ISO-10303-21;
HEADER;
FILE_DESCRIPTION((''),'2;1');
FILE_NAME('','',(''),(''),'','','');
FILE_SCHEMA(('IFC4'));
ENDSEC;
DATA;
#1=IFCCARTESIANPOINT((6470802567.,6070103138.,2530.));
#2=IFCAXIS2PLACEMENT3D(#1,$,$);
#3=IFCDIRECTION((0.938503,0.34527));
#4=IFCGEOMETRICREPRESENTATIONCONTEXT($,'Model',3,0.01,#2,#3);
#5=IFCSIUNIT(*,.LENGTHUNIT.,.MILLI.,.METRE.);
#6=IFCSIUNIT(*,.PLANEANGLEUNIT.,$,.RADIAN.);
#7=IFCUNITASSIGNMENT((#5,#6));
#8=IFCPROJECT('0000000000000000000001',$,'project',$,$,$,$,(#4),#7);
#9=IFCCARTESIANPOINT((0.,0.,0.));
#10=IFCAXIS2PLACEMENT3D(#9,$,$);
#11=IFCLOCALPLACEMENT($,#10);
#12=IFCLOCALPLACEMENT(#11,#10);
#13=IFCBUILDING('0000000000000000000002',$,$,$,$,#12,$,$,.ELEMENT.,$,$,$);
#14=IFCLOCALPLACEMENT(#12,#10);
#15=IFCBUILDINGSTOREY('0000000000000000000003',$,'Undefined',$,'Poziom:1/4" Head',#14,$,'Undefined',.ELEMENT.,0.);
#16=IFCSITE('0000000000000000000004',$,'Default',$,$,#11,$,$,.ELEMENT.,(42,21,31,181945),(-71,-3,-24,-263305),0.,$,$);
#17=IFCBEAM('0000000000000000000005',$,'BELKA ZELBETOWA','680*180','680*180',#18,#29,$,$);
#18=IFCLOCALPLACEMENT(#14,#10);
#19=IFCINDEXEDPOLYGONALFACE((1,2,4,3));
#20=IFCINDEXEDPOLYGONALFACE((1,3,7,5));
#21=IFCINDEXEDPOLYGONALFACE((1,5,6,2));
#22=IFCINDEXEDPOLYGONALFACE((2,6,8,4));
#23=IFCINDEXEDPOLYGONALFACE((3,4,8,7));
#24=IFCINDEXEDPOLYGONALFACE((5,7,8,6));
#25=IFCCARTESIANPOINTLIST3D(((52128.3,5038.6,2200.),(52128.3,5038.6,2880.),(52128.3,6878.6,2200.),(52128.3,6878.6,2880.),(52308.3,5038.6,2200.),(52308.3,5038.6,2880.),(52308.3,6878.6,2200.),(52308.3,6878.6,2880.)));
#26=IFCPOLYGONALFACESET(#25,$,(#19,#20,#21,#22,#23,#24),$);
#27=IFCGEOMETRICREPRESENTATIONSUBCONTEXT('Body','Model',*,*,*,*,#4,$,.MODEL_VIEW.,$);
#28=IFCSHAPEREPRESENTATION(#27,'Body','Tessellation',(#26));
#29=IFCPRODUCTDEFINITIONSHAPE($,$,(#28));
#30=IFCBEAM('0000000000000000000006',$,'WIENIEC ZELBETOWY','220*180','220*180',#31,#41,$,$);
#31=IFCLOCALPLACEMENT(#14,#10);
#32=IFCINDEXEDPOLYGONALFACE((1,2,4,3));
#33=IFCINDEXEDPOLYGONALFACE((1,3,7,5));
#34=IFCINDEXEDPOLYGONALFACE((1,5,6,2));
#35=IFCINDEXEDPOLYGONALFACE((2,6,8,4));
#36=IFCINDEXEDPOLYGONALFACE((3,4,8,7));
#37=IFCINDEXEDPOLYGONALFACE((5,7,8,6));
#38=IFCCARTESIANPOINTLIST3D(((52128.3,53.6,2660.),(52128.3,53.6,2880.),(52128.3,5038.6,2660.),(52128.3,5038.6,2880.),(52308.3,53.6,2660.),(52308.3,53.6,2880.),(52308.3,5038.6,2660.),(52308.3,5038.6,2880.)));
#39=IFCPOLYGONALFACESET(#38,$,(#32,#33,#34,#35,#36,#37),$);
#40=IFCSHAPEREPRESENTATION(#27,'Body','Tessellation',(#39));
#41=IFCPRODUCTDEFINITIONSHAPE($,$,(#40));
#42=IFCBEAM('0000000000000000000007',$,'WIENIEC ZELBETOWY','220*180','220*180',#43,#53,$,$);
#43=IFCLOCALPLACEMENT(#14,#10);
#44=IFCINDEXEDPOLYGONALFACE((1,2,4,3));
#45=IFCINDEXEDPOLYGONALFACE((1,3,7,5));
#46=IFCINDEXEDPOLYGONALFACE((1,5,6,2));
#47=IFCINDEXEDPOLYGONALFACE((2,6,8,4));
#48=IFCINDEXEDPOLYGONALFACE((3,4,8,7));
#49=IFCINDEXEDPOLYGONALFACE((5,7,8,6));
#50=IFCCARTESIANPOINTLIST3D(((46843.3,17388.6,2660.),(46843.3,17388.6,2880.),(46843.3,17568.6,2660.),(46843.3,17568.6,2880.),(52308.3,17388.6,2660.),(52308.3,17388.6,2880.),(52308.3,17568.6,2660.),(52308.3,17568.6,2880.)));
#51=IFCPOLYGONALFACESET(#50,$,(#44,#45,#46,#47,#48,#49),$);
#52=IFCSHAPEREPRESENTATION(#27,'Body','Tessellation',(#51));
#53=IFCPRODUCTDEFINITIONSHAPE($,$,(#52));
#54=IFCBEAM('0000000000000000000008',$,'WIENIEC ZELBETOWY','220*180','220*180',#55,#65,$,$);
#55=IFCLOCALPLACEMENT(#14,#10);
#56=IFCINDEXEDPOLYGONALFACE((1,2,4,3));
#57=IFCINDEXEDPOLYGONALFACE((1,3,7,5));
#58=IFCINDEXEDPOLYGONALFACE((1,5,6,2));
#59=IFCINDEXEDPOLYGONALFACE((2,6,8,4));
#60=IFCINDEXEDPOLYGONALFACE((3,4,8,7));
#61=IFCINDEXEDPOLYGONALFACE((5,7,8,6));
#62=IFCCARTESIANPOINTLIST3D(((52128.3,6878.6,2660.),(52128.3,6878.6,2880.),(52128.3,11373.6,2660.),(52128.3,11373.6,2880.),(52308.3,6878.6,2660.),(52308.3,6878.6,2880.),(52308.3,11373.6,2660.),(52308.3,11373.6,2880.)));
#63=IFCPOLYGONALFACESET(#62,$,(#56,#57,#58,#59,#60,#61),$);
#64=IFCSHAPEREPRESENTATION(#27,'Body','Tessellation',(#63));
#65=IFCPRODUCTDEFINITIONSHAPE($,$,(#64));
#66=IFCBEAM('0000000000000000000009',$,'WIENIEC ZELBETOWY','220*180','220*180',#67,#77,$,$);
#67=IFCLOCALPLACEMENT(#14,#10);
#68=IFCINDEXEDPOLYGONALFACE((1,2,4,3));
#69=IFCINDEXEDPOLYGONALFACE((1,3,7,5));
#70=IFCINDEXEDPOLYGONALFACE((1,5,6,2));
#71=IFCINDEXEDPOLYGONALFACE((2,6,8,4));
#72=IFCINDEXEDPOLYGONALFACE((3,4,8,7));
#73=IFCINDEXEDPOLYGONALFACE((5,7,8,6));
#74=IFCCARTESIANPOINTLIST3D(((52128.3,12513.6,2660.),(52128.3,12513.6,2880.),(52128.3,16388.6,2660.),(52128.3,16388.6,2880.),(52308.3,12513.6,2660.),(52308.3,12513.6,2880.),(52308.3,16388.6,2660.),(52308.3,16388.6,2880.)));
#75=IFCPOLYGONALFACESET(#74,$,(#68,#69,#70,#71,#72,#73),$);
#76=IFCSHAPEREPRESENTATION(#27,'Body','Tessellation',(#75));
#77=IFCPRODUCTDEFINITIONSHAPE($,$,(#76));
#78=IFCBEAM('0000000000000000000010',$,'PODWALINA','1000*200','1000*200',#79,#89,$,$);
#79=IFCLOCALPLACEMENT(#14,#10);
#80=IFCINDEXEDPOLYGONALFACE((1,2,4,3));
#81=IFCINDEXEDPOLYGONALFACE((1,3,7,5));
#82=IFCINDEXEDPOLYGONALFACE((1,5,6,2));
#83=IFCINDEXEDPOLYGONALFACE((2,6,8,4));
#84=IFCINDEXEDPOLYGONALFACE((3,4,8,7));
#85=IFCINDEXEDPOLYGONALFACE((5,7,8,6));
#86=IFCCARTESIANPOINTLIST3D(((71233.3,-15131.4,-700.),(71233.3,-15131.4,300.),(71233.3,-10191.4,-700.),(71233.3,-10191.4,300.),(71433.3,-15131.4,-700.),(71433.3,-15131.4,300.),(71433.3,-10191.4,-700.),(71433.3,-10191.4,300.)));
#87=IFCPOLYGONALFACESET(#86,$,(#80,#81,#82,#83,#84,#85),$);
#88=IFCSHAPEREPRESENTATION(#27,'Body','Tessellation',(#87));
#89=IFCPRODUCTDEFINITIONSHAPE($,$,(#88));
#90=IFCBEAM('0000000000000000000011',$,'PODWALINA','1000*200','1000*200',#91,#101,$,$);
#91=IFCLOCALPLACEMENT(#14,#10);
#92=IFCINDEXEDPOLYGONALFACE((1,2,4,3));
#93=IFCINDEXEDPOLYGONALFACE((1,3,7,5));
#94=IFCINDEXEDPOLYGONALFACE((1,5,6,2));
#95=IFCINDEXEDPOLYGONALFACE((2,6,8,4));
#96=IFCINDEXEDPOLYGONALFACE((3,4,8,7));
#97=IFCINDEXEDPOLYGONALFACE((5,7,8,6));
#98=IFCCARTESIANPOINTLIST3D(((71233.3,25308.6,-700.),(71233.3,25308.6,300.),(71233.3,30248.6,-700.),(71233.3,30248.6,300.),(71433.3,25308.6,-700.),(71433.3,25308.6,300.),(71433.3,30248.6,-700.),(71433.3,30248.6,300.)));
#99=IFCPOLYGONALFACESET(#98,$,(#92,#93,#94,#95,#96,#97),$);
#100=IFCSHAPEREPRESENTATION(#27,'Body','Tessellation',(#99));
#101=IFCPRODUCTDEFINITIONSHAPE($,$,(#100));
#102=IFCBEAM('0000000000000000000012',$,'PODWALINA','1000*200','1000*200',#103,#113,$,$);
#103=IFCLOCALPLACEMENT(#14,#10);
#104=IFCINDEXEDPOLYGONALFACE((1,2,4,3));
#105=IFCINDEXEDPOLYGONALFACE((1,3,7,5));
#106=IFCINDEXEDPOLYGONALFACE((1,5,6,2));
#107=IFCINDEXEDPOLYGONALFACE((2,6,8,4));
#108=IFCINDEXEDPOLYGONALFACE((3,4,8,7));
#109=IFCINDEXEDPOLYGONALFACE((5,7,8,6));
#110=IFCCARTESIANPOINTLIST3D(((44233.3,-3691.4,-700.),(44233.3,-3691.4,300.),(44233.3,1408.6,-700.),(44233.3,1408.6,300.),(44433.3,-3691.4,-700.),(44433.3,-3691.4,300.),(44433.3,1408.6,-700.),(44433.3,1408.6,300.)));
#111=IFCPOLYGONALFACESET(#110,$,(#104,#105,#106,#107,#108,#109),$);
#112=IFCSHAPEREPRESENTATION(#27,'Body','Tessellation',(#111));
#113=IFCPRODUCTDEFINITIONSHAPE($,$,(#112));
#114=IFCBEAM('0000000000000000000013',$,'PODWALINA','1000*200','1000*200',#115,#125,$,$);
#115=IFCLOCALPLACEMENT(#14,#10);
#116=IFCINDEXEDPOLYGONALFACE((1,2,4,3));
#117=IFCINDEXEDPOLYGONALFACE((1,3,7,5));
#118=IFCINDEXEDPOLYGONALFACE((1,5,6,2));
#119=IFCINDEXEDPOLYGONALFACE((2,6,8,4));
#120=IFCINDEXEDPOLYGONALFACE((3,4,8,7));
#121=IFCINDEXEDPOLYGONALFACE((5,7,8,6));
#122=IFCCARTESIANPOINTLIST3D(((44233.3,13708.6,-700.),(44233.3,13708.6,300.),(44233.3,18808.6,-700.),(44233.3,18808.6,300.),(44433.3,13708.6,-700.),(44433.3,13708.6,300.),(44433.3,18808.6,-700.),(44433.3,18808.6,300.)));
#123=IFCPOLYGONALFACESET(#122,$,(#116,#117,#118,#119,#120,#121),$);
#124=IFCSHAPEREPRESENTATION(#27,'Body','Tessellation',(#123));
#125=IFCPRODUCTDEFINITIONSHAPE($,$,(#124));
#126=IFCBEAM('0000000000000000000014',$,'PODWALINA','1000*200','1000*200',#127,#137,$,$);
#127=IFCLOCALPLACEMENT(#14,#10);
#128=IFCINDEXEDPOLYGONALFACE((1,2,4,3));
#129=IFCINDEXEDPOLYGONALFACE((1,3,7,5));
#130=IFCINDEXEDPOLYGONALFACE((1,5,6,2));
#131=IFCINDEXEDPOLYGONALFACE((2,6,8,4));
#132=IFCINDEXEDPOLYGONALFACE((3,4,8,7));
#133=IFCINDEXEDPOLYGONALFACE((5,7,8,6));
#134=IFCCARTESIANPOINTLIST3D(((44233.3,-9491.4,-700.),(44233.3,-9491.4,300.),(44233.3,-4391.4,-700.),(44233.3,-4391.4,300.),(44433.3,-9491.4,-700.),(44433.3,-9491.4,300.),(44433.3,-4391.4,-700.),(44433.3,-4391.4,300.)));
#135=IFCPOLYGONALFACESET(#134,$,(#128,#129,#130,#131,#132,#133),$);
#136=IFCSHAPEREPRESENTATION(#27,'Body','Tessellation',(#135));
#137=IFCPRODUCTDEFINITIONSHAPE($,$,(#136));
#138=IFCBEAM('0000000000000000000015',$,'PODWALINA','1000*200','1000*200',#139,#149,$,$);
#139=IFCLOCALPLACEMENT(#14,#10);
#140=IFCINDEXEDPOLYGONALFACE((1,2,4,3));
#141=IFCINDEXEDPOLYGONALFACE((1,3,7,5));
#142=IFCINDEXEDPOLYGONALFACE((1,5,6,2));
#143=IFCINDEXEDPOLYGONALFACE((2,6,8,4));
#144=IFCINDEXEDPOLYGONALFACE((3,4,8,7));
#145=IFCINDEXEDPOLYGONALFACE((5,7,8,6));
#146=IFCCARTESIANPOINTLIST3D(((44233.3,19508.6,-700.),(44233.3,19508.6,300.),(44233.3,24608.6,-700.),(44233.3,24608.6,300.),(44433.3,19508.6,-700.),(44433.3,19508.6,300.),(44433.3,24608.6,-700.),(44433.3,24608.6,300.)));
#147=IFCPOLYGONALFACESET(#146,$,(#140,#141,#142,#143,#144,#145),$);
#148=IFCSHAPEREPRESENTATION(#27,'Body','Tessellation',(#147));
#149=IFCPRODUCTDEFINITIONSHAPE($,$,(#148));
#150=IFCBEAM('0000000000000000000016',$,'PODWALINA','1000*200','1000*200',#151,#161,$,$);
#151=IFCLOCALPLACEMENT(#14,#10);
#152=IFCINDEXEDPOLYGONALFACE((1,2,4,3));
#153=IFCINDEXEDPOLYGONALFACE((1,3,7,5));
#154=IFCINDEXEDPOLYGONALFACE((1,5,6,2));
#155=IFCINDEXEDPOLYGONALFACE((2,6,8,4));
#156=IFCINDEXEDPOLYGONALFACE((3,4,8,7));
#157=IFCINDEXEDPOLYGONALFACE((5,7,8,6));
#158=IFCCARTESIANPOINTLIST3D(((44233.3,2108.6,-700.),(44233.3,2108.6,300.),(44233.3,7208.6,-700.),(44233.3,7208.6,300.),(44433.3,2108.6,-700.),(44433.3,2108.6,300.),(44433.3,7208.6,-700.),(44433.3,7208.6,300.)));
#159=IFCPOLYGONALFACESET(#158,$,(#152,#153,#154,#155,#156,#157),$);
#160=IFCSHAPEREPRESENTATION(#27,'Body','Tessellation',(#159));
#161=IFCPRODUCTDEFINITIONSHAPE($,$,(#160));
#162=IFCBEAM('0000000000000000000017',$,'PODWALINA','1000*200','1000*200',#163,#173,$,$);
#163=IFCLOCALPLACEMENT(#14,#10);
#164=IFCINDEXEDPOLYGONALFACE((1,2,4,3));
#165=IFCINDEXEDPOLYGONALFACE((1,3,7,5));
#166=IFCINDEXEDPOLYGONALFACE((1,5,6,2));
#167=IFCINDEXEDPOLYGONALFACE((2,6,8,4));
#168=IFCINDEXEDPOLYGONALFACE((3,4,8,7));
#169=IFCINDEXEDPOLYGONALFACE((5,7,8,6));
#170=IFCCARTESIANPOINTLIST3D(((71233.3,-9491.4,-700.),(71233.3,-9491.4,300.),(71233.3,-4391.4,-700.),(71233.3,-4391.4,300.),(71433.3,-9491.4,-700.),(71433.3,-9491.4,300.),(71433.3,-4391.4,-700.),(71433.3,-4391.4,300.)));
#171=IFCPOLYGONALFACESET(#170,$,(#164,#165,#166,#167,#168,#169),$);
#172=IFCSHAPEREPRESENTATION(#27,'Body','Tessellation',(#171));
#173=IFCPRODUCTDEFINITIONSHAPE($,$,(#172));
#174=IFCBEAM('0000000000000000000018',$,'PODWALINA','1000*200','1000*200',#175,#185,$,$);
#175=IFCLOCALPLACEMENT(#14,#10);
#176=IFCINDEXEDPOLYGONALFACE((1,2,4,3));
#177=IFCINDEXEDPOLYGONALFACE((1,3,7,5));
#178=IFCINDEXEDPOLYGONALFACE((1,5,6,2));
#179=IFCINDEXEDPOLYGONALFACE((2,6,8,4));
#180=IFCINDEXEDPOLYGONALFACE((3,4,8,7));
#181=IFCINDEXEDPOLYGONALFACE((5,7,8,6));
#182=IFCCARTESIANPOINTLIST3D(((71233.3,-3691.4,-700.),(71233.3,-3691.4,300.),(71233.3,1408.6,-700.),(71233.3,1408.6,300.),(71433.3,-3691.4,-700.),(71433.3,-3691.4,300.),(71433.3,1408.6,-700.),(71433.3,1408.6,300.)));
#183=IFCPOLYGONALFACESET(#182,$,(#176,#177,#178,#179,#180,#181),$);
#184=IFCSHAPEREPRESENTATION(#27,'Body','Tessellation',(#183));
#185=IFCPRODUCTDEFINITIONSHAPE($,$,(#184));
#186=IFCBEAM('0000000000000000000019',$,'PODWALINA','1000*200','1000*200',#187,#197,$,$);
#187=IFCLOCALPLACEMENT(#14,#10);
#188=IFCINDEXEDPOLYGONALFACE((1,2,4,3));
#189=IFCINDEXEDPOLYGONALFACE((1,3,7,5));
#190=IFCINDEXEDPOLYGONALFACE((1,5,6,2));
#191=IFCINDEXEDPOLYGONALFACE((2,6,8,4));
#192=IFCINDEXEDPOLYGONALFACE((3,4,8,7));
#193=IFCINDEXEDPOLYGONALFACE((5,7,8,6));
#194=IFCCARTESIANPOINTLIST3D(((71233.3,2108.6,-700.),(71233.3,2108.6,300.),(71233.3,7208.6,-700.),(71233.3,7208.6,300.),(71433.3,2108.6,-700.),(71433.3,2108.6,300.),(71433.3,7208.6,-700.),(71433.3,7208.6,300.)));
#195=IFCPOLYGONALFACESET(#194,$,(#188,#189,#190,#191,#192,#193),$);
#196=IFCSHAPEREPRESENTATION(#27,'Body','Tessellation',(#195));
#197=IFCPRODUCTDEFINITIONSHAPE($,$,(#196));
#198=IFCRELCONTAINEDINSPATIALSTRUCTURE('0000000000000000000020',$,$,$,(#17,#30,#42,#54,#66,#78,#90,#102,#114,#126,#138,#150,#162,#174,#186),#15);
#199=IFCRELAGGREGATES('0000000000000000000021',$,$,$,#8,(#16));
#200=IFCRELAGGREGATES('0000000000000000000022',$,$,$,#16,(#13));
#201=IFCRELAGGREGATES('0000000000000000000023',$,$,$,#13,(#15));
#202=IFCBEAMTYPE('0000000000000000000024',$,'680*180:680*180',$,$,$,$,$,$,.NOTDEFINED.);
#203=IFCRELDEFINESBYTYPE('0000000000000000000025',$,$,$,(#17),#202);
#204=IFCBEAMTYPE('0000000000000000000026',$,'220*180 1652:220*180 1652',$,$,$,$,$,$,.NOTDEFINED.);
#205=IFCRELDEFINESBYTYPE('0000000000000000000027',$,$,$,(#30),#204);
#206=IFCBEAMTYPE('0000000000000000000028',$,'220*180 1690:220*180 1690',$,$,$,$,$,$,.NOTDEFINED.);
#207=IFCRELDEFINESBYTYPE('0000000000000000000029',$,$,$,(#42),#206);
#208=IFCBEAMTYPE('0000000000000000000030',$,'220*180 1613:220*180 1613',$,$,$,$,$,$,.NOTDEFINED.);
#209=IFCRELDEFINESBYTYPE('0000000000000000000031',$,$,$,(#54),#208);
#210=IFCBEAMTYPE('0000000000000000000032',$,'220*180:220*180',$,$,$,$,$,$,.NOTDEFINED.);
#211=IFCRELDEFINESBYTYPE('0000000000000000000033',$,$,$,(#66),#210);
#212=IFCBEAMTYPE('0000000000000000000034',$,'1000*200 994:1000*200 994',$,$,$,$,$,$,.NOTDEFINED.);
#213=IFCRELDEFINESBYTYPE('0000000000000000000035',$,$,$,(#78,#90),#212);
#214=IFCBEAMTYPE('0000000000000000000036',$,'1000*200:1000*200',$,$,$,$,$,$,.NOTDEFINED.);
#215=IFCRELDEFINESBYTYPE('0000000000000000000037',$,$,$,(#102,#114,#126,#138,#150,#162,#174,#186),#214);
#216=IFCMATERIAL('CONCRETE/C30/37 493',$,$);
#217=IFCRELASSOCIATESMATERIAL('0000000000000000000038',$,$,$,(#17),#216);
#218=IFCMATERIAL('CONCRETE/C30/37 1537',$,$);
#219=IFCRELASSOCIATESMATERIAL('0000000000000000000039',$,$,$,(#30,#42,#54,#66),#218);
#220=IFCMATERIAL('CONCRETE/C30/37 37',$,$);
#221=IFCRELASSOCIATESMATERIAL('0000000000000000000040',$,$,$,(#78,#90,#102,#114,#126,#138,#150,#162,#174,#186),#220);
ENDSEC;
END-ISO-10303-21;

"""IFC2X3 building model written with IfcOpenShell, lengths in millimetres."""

from ifc_helpers import new_model, si_unit, direction, frame, frame_2d, origin, place, context, subcontext, project, spatial, rectangle, extrude, material, type_object, element, save


model = new_model("IFC2X3")

# Units and contexts
model_context = context("Model", 3, precision=0.01, world=frame((6470802567.0, 6070103138.0, 2530.0)), true_north=direction((0.938503, 0.34527)))
body_context = subcontext(model_context, "Body", "Model", "MODEL_VIEW")
ifc_project = project(units=[si_unit("LENGTHUNIT", "METRE", prefix="MILLI"), si_unit("PLANEANGLEUNIT", "RADIAN")], contexts=[model_context])

# Site, building, storey
site_placement = place(None, origin())
site = spatial("IfcSite", under=ifc_project, at=site_placement, Name="Default", CompositionType="ELEMENT", RefLatitude=(42, 21, 31, 181945), RefLongitude=(-71, -3, -24, -263305), RefElevation=0.0)
building_placement = place(site_placement, origin())
building = spatial("IfcBuilding", under=site, at=building_placement, CompositionType="ELEMENT")
storey_placement = place(building_placement, origin())
storey = spatial("IfcBuildingStorey", under=building, at=storey_placement, Name="Undefined", ObjectType="Poziom:1/4\" Head", LongName="Undefined", CompositionType="ELEMENT", Elevation=0.0)

# Beams
ifc_material_1 = material(Name="CONCRETE/C30/37 493")
beam_type_1 = type_object("IfcBeamType", Name="680*180:680*180", PredefinedType="NOTDEFINED")
beam_1_placement = place(storey_placement, origin())
element("IfcBeam", 1, at=beam_1_placement, inside=storey, type_object=beam_type_1, material=ifc_material_1, Name="BELKA ZELBETOWA", Description="680*180", ObjectType="680*180", context=body_context, shape_type="SweptSolid", body=[
    extrude(rectangle(XDim=680.0, YDim=1840.0, at=frame_2d((0.0, 0.0), x_axis=(0.0, 1.0))), frame((52128.3, 5958.6, 2540.0), z_axis=(1.0, 0.0, 0.0), x_axis=(0.0, -1.0, 0.0)), (0.0, 0.0, 1.0), 180.0),
])
ifc_material_2 = material(Name="CONCRETE/C30/37 1537")
beam_type_2 = type_object("IfcBeamType", Name="220*180 1652:220*180 1652", PredefinedType="NOTDEFINED")
beam_2_placement = place(storey_placement, origin())
element("IfcBeam", 2, at=beam_2_placement, inside=storey, type_object=beam_type_2, material=ifc_material_2, Name="WIENIEC ZELBETOWY", Description="220*180", ObjectType="220*180", context=body_context, shape_type="SweptSolid", body=[
    extrude(rectangle(XDim=220.0, YDim=4985.0, at=frame_2d((0.0, 0.0), x_axis=(0.0, 1.0))), frame((52128.3, 2546.1, 2770.0), z_axis=(1.0, 0.0, 0.0), x_axis=(0.0, -1.0, 0.0)), (0.0, 0.0, 1.0), 180.0),
])
beam_type_3 = type_object("IfcBeamType", Name="220*180 1690:220*180 1690", PredefinedType="NOTDEFINED")
beam_3_placement = place(storey_placement, origin())
element("IfcBeam", 3, at=beam_3_placement, inside=storey, type_object=beam_type_3, material=ifc_material_2, Name="WIENIEC ZELBETOWY", Description="220*180", ObjectType="220*180", context=body_context, shape_type="SweptSolid", body=[
    extrude(rectangle(XDim=220.0, YDim=180.0, at=frame_2d((0.0, 0.0), x_axis=(1.0, 0.0))), frame((46843.3, 17478.6, 2770.0), z_axis=(1.0, 0.0, 0.0), x_axis=(0.0, 0.0, -1.0)), (0.0, 0.0, 1.0), 5465.0),
])
beam_type_4 = type_object("IfcBeamType", Name="220*180 1613:220*180 1613", PredefinedType="NOTDEFINED")
beam_4_placement = place(storey_placement, origin())
element("IfcBeam", 4, at=beam_4_placement, inside=storey, type_object=beam_type_4, material=ifc_material_2, Name="WIENIEC ZELBETOWY", Description="220*180", ObjectType="220*180", context=body_context, shape_type="SweptSolid", body=[
    extrude(rectangle(XDim=220.0, YDim=4495.0, at=frame_2d((0.0, 0.0), x_axis=(0.0, 1.0))), frame((52128.3, 9126.1, 2770.0), z_axis=(1.0, 0.0, 0.0), x_axis=(0.0, -1.0, 0.0)), (0.0, 0.0, 1.0), 180.0),
])
beam_type_5 = type_object("IfcBeamType", Name="220*180:220*180", PredefinedType="NOTDEFINED")
beam_5_placement = place(storey_placement, origin())
element("IfcBeam", 5, at=beam_5_placement, inside=storey, type_object=beam_type_5, material=ifc_material_2, Name="WIENIEC ZELBETOWY", Description="220*180", ObjectType="220*180", context=body_context, shape_type="SweptSolid", body=[
    extrude(rectangle(XDim=220.0, YDim=3875.0, at=frame_2d((0.0, 0.0), x_axis=(0.0, 1.0))), frame((52128.3, 14451.1, 2770.0), z_axis=(1.0, 0.0, 0.0), x_axis=(0.0, -1.0, 0.0)), (0.0, 0.0, 1.0), 180.0),
])
ifc_material_3 = material(Name="CONCRETE/C30/37 37")
beam_type_6 = type_object("IfcBeamType", Name="1000*200 994:1000*200 994", PredefinedType="NOTDEFINED")
beam_6_placement = place(storey_placement, origin())
element("IfcBeam", 6, at=beam_6_placement, inside=storey, type_object=beam_type_6, material=ifc_material_3, Name="PODWALINA", Description="1000*200", ObjectType="1000*200", context=body_context, shape_type="SweptSolid", body=[
    extrude(rectangle(XDim=1000.0, YDim=4940.0, at=frame_2d((0.0, 0.0), x_axis=(0.0, 1.0))), frame((71233.3, -12661.4, -200.0), z_axis=(1.0, 0.0, 0.0), x_axis=(0.0, -1.0, 0.0)), (0.0, 0.0, 1.0), 200.0),
])
beam_7_placement = place(storey_placement, origin())
element("IfcBeam", 7, at=beam_7_placement, inside=storey, type_object=beam_type_6, material=ifc_material_3, Name="PODWALINA", Description="1000*200", ObjectType="1000*200", context=body_context, shape_type="SweptSolid", body=[
    extrude(rectangle(XDim=1000.0, YDim=4940.0, at=frame_2d((0.0, 0.0), x_axis=(0.0, 1.0))), frame((71233.3, 27778.6, -200.0), z_axis=(1.0, 0.0, 0.0), x_axis=(0.0, -1.0, 0.0)), (0.0, 0.0, 1.0), 200.0),
])
beam_type_7 = type_object("IfcBeamType", Name="1000*200:1000*200", PredefinedType="NOTDEFINED")
beam_8_placement = place(storey_placement, origin())
element("IfcBeam", 8, at=beam_8_placement, inside=storey, type_object=beam_type_7, material=ifc_material_3, Name="PODWALINA", Description="1000*200", ObjectType="1000*200", context=body_context, shape_type="SweptSolid", body=[
    extrude(rectangle(XDim=1000.0, YDim=5100.0, at=frame_2d((0.0, 0.0), x_axis=(0.0, 1.0))), frame((44233.3, -1141.4, -200.0), z_axis=(1.0, 0.0, 0.0), x_axis=(0.0, -1.0, 0.0)), (0.0, 0.0, 1.0), 200.0),
])
beam_9_placement = place(storey_placement, origin())
element("IfcBeam", 9, at=beam_9_placement, inside=storey, type_object=beam_type_7, material=ifc_material_3, Name="PODWALINA", Description="1000*200", ObjectType="1000*200", context=body_context, shape_type="SweptSolid", body=[
    extrude(rectangle(XDim=1000.0, YDim=5100.0, at=frame_2d((0.0, 0.0), x_axis=(0.0, 1.0))), frame((44233.3, 16258.6, -200.0), z_axis=(1.0, 0.0, 0.0), x_axis=(0.0, -1.0, 0.0)), (0.0, 0.0, 1.0), 200.0),
])
beam_10_placement = place(storey_placement, origin())
element("IfcBeam", 10, at=beam_10_placement, inside=storey, type_object=beam_type_7, material=ifc_material_3, Name="PODWALINA", Description="1000*200", ObjectType="1000*200", context=body_context, shape_type="SweptSolid", body=[
    extrude(rectangle(XDim=1000.0, YDim=5100.0, at=frame_2d((0.0, 0.0), x_axis=(0.0, 1.0))), frame((44233.3, -6941.4, -200.0), z_axis=(1.0, 0.0, 0.0), x_axis=(0.0, -1.0, 0.0)), (0.0, 0.0, 1.0), 200.0),
])
beam_11_placement = place(storey_placement, origin())
element("IfcBeam", 11, at=beam_11_placement, inside=storey, type_object=beam_type_7, material=ifc_material_3, Name="PODWALINA", Description="1000*200", ObjectType="1000*200", context=body_context, shape_type="SweptSolid", body=[
    extrude(rectangle(XDim=1000.0, YDim=5100.0, at=frame_2d((0.0, 0.0), x_axis=(0.0, 1.0))), frame((44233.3, 22058.6, -200.0), z_axis=(1.0, 0.0, 0.0), x_axis=(0.0, -1.0, 0.0)), (0.0, 0.0, 1.0), 200.0),
])
beam_12_placement = place(storey_placement, origin())
element("IfcBeam", 12, at=beam_12_placement, inside=storey, type_object=beam_type_7, material=ifc_material_3, Name="PODWALINA", Description="1000*200", ObjectType="1000*200", context=body_context, shape_type="SweptSolid", body=[
    extrude(rectangle(XDim=1000.0, YDim=5100.0, at=frame_2d((0.0, 0.0), x_axis=(0.0, 1.0))), frame((44233.3, 4658.6, -200.0), z_axis=(1.0, 0.0, 0.0), x_axis=(0.0, -1.0, 0.0)), (0.0, 0.0, 1.0), 200.0),
])
beam_13_placement = place(storey_placement, origin())
element("IfcBeam", 13, at=beam_13_placement, inside=storey, type_object=beam_type_7, material=ifc_material_3, Name="PODWALINA", Description="1000*200", ObjectType="1000*200", context=body_context, shape_type="SweptSolid", body=[
    extrude(rectangle(XDim=1000.0, YDim=5100.0, at=frame_2d((0.0, 0.0), x_axis=(0.0, 1.0))), frame((71233.3, -6941.4, -200.0), z_axis=(1.0, 0.0, 0.0), x_axis=(0.0, -1.0, 0.0)), (0.0, 0.0, 1.0), 200.0),
])
beam_14_placement = place(storey_placement, origin())
element("IfcBeam", 14, at=beam_14_placement, inside=storey, type_object=beam_type_7, material=ifc_material_3, Name="PODWALINA", Description="1000*200", ObjectType="1000*200", context=body_context, shape_type="SweptSolid", body=[
    extrude(rectangle(XDim=1000.0, YDim=5100.0, at=frame_2d((0.0, 0.0), x_axis=(0.0, 1.0))), frame((71233.3, -1141.4, -200.0), z_axis=(1.0, 0.0, 0.0), x_axis=(0.0, -1.0, 0.0)), (0.0, 0.0, 1.0), 200.0),
])
beam_15_placement = place(storey_placement, origin())
element("IfcBeam", 15, at=beam_15_placement, inside=storey, type_object=beam_type_7, material=ifc_material_3, Name="PODWALINA", Description="1000*200", ObjectType="1000*200", context=body_context, shape_type="SweptSolid", body=[
    extrude(rectangle(XDim=1000.0, YDim=5100.0, at=frame_2d((0.0, 0.0), x_axis=(0.0, 1.0))), frame((71233.3, 4658.6, -200.0), z_axis=(1.0, 0.0, 0.0), x_axis=(0.0, -1.0, 0.0)), (0.0, 0.0, 1.0), 200.0),
])

save(model, "model.ifc")
